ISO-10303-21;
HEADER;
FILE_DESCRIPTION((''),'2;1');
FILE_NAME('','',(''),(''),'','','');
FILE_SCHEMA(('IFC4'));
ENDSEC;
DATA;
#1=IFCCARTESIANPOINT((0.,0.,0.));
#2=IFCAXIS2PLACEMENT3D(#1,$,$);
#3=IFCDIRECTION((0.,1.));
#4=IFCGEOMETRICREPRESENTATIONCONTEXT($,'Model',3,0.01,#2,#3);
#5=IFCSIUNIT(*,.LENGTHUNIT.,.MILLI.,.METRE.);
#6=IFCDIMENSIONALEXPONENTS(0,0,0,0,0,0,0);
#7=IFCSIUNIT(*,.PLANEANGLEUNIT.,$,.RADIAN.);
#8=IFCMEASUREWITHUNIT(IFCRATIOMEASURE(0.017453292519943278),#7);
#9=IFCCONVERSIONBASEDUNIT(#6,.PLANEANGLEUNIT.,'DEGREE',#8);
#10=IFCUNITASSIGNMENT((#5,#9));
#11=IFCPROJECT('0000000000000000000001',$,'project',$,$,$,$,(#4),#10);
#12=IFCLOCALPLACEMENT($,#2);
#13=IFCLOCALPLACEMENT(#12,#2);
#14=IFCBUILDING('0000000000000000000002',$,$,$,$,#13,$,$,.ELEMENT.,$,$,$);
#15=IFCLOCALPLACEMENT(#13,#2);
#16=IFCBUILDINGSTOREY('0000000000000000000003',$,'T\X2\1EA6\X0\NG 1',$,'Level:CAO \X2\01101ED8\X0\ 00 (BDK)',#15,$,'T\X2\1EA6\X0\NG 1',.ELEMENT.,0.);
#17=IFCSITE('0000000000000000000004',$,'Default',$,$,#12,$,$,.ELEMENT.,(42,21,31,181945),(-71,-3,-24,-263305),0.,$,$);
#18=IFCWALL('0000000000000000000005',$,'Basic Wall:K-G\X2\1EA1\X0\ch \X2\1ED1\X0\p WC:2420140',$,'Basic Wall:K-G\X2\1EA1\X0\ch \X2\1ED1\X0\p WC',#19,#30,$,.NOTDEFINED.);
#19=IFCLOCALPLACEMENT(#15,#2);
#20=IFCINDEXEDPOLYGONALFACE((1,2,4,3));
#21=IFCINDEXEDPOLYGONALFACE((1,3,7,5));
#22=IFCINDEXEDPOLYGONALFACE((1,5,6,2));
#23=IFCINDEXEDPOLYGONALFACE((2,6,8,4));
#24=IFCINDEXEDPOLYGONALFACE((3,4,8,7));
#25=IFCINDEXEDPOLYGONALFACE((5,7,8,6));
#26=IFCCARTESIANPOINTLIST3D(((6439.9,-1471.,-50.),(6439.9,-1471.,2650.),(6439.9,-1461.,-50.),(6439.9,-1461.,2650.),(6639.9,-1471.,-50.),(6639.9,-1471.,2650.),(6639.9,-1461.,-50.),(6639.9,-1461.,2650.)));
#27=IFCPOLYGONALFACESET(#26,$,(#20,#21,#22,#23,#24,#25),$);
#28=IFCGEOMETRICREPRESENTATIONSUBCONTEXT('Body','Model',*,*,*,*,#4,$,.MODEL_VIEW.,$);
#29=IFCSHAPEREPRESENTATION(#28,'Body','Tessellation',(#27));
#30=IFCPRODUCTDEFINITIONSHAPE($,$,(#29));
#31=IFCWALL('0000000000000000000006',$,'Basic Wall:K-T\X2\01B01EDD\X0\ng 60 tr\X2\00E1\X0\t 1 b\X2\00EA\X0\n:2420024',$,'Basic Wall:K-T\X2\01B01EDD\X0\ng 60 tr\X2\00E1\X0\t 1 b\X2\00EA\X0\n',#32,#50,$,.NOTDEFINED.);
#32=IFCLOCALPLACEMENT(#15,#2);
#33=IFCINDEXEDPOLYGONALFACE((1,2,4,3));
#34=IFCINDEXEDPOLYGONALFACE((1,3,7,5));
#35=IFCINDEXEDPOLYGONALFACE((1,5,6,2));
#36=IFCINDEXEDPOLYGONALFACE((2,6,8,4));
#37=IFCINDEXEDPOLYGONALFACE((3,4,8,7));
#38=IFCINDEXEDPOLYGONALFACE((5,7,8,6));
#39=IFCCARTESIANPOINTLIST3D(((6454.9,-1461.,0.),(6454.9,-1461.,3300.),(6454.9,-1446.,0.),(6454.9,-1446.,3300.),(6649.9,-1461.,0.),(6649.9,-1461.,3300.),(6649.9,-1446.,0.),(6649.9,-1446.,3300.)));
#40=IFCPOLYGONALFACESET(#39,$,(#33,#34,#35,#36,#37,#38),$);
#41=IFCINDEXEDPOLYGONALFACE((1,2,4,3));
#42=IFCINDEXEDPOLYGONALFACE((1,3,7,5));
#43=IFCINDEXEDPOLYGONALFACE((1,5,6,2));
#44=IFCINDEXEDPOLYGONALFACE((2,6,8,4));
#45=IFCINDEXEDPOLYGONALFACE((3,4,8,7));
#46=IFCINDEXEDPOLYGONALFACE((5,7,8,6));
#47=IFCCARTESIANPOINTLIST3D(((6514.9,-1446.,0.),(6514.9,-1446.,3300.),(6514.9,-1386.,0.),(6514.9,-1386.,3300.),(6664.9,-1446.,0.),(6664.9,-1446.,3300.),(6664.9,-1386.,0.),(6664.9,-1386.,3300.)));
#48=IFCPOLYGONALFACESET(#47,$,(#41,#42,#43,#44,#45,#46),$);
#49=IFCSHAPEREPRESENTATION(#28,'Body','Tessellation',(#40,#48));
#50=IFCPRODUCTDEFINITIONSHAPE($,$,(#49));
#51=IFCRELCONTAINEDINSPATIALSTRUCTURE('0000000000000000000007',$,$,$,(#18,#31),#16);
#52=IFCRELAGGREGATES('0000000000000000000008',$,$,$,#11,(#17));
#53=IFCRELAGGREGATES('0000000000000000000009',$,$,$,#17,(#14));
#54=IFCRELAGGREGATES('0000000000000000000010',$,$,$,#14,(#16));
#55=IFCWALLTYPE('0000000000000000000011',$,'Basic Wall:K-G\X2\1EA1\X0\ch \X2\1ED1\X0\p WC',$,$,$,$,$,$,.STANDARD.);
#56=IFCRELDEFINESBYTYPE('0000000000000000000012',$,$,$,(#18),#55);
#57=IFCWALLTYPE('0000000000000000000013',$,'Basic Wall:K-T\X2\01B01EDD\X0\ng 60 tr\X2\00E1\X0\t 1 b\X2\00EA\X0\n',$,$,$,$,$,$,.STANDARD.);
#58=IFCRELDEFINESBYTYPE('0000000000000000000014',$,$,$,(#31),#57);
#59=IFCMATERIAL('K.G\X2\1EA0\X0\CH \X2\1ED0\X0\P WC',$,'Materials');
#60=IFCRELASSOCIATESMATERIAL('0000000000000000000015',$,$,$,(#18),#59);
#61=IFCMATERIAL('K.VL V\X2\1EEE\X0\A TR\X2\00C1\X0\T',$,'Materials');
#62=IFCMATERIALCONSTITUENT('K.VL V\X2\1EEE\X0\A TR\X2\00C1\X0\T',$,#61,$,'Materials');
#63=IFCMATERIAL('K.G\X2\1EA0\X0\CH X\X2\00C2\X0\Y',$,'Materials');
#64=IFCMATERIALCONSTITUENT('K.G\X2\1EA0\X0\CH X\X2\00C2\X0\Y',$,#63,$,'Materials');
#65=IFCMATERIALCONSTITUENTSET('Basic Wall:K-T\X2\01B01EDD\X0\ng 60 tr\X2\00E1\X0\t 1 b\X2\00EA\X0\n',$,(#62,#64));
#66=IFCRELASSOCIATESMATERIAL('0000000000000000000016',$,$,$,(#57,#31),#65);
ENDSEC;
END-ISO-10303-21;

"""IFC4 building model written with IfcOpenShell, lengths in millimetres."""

from ifc_helpers import new_model, entity, si_unit, converted_unit, direction, frame, origin, place, context, subcontext, project, spatial, indexed_curve, outline, extrude, material, constituent, constituent_set, type_object, element, save


model = new_model("IFC4")

# Units and contexts
model_context = context("Model", 3, precision=0.01, world=origin(), true_north=direction((0.0, 1.0)))
body_context = subcontext(model_context, "Body", "Model", "MODEL_VIEW")
ifc_project = project(units=[si_unit("LENGTHUNIT", "METRE", prefix="MILLI"), converted_unit("PLANEANGLEUNIT", "DEGREE", entity("IfcRatioMeasure", 0.017453292519943278), si_unit("PLANEANGLEUNIT", "RADIAN"), dimensions=[0, 0, 0, 0, 0, 0, 0])], contexts=[model_context])

# Site, building, storey
site_placement = place(None, origin())
site = spatial("IfcSite", under=ifc_project, at=site_placement, Name="Default", CompositionType="ELEMENT", RefLatitude=(42, 21, 31, 181945), RefLongitude=(-71, -3, -24, -263305), RefElevation=0.0)
building_placement = place(site_placement, origin())
building = spatial("IfcBuilding", under=site, at=building_placement, CompositionType="ELEMENT")
storey_placement = place(building_placement, origin())
storey = spatial("IfcBuildingStorey", under=building, at=storey_placement, Name="TẦNG 1", ObjectType="Level:CAO ĐỘ 00 (BDK)", LongName="TẦNG 1", CompositionType="ELEMENT", Elevation=0.0)

# Shared definitions
ifc_material_1 = material(Name="K.VL VỮA TRÁT", Category="Materials")
ifc_material_2 = material(Name="K.GẠCH XÂY", Category="Materials")

# Walls
ifc_material_3 = material(Name="K.GẠCH ỐP WC", Category="Materials")
wall_type_1 = type_object("IfcWallType", Name="Basic Wall:K-Gạch ốp WC", PredefinedType="STANDARD")
wall_1_placement = place(storey_placement, frame((6439.9, -1466.0, -50.0)))
element("IfcWall", 1, at=wall_1_placement, inside=storey, type_object=wall_type_1, material=ifc_material_3, Name="Basic Wall:K-Gạch ốp WC:2420140", ObjectType="Basic Wall:K-Gạch ốp WC", PredefinedType="NOTDEFINED", context=body_context, shape_type="SweptSolid", body=[
    extrude(outline(indexed_curve([(200.0, 5.0), (0.0, 5.0), (0.0, -5.0), (200.0, -5.0), (200.0, 5.0)], self_intersect=False)), origin(), (0.0, 0.0, 1.0), 2700.0),
])
ifc_constituent_1 = constituent(ifc_material_1, Name="K.VL VỮA TRÁT", Category="Materials")
ifc_constituent_2 = constituent(ifc_material_2, Name="K.GẠCH XÂY", Category="Materials")
ifc_constituent_set_1 = constituent_set(constituents=[ifc_constituent_1, ifc_constituent_2], Name="Basic Wall:K-Tường 60 trát 1 bên")
wall_type_2 = type_object("IfcWallType", Name="Basic Wall:K-Tường 60 trát 1 bên", PredefinedType="STANDARD", material=ifc_constituent_set_1)
wall_2_placement = place(storey_placement, frame((6514.9, -1423.5, 0.0)))
element("IfcWall", 2, at=wall_2_placement, inside=storey, type_object=wall_type_2, material=ifc_constituent_set_1, Name="Basic Wall:K-Tường 60 trát 1 bên:2420024", ObjectType="Basic Wall:K-Tường 60 trát 1 bên", PredefinedType="NOTDEFINED", context=body_context, shape_type="SweptSolid", body=[
    extrude(outline(indexed_curve([(-7.5, -97.5), (7.5, -97.5), (7.5, 97.5), (-7.5, 97.5), (-7.5, -97.5)], self_intersect=False)), frame((37.5, -30.0, 0.0), z_axis=(0.0, 0.0, 1.0), x_axis=(0.0, 1.0, 0.0)), (0.0, 0.0, 1.0), 3300.0),
    extrude(outline(indexed_curve([(-30.0, -75.0), (30.0, -75.0), (30.0, 75.0), (-30.0, 75.0), (-30.0, -75.0)], self_intersect=False)), frame((75.0, 7.5, 0.0), z_axis=(0.0, 0.0, 1.0), x_axis=(0.0, -1.0, 0.0)), (0.0, 0.0, 1.0), 3300.0),
])

save(model, "model.ifc")
